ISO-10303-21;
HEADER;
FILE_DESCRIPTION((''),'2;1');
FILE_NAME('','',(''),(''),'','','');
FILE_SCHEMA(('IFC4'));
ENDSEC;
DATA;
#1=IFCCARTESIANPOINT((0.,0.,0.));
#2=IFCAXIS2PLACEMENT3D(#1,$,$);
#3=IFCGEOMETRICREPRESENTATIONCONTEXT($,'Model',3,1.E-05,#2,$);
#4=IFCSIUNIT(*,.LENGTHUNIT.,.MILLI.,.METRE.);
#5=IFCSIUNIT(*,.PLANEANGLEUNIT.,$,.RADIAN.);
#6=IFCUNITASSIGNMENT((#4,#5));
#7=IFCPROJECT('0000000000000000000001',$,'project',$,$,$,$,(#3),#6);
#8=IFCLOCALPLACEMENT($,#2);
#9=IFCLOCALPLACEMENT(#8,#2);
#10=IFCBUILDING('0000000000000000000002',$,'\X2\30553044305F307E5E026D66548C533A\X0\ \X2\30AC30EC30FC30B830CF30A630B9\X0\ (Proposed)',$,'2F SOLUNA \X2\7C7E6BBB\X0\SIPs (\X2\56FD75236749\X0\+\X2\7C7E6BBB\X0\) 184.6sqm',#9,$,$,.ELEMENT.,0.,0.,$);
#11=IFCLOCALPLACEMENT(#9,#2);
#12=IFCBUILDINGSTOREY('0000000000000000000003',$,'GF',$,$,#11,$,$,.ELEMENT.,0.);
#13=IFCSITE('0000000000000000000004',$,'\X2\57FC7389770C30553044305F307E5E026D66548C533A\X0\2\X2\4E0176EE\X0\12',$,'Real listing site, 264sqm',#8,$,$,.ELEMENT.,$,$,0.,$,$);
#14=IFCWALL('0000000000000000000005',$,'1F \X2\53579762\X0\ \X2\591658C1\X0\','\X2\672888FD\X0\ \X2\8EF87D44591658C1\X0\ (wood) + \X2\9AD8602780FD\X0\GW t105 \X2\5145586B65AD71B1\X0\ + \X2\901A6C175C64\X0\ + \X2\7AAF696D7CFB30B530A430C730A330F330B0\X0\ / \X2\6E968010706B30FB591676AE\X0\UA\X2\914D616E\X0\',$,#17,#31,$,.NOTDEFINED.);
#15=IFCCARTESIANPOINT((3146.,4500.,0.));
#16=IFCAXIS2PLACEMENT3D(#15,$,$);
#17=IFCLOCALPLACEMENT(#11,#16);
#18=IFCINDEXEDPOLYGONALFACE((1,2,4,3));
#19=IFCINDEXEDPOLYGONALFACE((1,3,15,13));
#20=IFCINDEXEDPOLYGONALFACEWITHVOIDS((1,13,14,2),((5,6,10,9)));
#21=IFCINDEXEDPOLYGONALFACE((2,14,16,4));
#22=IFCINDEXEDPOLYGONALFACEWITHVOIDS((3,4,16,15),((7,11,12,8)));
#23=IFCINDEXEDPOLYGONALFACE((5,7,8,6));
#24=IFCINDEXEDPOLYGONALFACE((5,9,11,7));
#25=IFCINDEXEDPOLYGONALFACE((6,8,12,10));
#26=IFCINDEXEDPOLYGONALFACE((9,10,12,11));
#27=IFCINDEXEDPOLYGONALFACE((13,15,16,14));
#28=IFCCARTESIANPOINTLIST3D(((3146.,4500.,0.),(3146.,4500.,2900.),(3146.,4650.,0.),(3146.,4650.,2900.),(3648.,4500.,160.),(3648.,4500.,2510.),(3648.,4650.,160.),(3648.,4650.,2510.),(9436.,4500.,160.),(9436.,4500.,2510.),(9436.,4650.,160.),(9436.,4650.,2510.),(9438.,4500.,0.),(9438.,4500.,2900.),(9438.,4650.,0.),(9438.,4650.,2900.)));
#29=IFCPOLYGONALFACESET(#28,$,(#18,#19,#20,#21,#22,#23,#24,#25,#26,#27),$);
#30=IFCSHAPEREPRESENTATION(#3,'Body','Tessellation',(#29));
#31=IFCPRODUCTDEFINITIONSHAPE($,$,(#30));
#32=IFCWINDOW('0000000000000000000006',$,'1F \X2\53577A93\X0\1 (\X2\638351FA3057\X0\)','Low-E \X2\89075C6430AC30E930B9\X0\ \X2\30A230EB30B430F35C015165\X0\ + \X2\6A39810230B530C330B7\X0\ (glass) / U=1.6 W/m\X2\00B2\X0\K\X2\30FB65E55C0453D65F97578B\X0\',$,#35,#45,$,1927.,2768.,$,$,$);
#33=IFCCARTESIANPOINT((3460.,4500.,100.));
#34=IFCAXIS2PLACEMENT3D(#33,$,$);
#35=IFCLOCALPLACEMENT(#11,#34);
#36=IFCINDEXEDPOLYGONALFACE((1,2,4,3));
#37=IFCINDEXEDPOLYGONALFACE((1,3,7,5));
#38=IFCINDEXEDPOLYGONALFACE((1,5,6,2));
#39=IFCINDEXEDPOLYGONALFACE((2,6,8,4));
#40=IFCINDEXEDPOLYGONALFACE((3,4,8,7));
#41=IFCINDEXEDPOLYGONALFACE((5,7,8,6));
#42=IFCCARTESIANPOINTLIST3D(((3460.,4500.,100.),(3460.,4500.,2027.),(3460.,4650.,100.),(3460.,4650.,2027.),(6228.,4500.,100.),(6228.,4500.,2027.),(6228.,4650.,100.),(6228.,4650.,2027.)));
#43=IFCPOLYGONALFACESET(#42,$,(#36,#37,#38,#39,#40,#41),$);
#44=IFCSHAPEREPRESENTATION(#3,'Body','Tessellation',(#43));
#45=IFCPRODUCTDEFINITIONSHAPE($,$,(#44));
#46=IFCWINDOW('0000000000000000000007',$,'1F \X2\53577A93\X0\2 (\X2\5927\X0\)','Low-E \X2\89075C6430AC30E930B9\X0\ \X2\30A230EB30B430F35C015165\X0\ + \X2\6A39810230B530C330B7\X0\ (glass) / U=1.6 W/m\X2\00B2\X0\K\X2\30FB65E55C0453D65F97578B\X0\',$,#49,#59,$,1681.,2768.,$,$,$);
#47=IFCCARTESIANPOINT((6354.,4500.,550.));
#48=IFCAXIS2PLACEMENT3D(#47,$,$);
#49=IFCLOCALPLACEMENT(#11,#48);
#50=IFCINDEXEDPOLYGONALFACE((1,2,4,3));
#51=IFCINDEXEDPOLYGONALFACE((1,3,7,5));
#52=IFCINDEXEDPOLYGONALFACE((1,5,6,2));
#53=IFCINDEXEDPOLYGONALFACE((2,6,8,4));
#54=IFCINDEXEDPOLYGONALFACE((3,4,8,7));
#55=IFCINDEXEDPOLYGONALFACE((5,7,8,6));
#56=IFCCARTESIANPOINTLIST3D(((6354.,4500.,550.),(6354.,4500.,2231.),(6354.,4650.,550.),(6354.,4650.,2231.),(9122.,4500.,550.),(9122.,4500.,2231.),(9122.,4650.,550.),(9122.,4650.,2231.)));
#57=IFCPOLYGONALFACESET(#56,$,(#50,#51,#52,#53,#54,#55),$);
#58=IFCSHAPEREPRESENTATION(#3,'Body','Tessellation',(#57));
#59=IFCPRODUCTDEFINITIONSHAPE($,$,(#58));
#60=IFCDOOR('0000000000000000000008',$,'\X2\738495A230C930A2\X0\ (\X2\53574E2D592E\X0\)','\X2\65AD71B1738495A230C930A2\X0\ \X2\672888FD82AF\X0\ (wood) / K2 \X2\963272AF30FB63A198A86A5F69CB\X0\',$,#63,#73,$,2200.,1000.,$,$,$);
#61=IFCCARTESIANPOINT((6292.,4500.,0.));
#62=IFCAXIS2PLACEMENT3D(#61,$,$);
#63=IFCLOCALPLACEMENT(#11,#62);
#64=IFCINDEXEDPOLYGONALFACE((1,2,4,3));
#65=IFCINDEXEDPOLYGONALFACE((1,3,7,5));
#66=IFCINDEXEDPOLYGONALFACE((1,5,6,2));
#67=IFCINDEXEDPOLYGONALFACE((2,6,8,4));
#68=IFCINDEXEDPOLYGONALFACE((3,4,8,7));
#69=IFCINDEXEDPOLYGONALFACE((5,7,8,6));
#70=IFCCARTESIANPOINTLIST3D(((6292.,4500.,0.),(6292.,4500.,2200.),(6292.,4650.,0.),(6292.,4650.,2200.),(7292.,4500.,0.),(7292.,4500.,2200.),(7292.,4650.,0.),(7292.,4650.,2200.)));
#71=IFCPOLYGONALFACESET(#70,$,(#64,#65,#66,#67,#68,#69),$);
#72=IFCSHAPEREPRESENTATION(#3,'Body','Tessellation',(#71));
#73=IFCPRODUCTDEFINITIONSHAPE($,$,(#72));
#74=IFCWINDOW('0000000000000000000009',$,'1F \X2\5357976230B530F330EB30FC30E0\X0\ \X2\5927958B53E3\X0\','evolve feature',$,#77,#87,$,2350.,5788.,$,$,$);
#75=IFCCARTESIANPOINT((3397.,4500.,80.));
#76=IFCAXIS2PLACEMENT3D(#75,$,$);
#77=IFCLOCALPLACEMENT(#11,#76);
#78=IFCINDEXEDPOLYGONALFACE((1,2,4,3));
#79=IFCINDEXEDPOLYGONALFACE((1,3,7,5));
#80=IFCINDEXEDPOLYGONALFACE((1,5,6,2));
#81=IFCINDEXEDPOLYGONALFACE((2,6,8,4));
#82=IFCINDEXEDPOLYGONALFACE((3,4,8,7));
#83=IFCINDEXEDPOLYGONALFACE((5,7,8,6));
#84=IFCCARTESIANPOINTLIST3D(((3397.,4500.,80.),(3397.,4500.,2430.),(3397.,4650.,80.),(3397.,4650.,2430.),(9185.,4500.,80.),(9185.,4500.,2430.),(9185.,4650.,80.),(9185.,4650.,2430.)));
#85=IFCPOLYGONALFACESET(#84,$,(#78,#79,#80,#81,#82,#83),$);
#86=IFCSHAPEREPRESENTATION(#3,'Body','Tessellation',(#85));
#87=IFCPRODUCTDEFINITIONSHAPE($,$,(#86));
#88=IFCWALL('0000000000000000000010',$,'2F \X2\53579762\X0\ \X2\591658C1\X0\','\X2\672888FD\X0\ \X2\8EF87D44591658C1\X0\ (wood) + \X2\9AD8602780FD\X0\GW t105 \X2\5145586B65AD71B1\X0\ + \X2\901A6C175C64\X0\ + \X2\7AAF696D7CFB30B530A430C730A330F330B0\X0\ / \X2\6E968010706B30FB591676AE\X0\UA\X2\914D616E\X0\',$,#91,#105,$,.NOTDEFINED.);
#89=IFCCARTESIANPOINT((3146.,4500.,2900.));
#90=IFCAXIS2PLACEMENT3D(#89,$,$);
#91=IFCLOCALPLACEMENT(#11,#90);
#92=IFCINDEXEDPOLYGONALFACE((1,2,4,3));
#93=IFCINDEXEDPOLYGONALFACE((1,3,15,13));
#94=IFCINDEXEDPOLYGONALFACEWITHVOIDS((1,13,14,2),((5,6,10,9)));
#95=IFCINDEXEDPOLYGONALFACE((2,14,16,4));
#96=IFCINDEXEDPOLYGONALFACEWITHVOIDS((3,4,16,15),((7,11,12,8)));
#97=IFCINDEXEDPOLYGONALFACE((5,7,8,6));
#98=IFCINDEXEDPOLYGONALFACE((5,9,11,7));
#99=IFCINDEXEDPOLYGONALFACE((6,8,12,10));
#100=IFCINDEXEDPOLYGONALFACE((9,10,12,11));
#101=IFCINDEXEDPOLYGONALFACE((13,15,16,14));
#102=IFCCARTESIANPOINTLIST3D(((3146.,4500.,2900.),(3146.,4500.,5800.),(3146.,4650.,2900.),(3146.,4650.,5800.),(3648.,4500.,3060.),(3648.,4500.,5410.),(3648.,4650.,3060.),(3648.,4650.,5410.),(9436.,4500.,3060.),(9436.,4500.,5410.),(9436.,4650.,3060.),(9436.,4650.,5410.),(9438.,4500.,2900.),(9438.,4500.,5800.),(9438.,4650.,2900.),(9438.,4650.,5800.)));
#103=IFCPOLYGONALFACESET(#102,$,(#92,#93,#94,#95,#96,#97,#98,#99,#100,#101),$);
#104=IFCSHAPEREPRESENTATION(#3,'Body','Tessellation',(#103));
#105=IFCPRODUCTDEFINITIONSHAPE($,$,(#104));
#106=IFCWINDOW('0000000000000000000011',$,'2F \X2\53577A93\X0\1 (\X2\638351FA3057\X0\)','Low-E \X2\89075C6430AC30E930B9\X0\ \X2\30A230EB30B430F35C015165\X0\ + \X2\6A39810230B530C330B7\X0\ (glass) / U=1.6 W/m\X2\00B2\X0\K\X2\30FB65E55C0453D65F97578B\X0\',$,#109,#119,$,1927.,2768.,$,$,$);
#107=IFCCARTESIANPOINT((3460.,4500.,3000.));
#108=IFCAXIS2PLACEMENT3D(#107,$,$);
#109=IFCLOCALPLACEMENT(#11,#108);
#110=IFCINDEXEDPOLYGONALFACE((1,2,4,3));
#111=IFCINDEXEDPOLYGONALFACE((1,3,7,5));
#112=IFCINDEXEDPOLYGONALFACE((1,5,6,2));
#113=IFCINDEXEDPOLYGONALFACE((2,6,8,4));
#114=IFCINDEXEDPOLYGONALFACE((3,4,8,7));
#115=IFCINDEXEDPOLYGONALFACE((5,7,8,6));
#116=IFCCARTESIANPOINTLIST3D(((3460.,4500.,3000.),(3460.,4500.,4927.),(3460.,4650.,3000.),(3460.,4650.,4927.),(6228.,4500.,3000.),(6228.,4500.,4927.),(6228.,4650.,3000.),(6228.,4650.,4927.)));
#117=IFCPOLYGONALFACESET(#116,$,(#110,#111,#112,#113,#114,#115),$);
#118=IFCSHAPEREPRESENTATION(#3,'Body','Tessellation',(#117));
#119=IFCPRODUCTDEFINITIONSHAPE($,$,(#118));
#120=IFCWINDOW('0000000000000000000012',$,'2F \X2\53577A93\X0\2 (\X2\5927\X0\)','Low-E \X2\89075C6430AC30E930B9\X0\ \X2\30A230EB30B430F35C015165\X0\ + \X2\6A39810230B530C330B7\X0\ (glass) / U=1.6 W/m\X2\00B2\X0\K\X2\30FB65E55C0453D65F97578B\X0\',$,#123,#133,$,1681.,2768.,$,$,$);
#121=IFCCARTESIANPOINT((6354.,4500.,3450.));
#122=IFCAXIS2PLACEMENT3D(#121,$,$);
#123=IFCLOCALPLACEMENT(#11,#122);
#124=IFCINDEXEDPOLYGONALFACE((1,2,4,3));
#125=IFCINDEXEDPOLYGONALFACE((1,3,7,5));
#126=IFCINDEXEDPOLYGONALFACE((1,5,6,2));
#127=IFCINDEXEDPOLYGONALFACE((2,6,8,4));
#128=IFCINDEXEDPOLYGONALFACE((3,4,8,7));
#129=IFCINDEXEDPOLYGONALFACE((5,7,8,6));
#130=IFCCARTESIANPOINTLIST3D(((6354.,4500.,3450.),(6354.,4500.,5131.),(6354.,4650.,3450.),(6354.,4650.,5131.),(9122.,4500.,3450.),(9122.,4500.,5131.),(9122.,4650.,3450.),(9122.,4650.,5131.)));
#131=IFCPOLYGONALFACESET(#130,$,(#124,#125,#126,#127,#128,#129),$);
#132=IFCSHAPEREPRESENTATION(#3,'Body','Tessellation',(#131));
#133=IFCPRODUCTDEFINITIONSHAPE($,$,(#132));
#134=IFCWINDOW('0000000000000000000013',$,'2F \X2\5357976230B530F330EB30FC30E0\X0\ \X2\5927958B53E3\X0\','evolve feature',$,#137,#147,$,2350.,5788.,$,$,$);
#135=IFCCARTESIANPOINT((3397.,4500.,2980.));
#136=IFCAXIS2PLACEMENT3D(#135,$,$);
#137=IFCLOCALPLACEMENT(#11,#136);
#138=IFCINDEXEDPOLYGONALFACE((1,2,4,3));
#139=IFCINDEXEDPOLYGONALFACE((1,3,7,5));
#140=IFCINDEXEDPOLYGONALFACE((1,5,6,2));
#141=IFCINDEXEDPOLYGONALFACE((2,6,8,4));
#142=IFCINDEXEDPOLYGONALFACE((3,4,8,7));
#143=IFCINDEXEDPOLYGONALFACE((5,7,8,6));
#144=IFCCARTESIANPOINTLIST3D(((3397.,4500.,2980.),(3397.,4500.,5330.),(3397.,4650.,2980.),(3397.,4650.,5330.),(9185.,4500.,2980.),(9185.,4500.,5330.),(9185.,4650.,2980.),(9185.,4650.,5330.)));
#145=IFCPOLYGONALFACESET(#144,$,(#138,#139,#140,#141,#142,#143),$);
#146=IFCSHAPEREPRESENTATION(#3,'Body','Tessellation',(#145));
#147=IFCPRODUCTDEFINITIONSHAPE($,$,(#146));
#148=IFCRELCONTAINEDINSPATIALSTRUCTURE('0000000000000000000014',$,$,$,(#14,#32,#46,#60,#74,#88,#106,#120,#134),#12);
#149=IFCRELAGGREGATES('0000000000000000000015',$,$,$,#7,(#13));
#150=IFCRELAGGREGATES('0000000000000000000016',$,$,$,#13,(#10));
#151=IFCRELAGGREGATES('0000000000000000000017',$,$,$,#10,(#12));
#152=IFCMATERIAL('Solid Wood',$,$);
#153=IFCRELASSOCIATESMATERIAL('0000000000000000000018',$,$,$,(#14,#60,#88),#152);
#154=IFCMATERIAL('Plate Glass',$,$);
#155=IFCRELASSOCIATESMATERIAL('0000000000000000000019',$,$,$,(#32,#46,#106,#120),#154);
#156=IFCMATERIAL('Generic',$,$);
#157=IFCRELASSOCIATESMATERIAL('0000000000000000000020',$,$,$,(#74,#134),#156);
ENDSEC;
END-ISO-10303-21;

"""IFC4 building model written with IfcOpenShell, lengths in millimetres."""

from ifc_helpers import new_model, si_unit, frame, frame_2d, origin, place, context, project, spatial, rectangle, extrude, material, element, fill, save


model = new_model("IFC4")

# Units and contexts
model_context = context("Model", 3, precision=1e-05, world=origin())
ifc_project = project(units=[si_unit("LENGTHUNIT", "METRE", prefix="MILLI"), si_unit("PLANEANGLEUNIT", "RADIAN")], contexts=[model_context])

# Site, building, storey
site_placement = place(None, origin())
site = spatial("IfcSite", under=ifc_project, at=site_placement, Name="埼玉県さいたま市浦和区2丁目12", ObjectType="Real listing site, 264sqm", CompositionType="ELEMENT", RefElevation=0.0)
building_placement = place(site_placement, origin())
building = spatial("IfcBuilding", under=site, at=building_placement, Name="さいたま市浦和区 ガレージハウス (Proposed)", ObjectType="2F SOLUNA 籾殻SIPs (国産杉+籾殻) 184.6sqm", CompositionType="ELEMENT", ElevationOfRefHeight=0.0, ElevationOfTerrain=0.0)
storey_placement = place(building_placement, origin())
storey = spatial("IfcBuildingStorey", under=building, at=storey_placement, Name="GF", CompositionType="ELEMENT", Elevation=0.0)

# Shared definitions
ifc_material_1 = material(Name="Solid Wood")
ifc_material_2 = material(Name="Generic")

# Wall, openings, windows, door
wall_1_placement = place(storey_placement, frame((3146.0, 4500.0, 0.0)))
wall_1 = element("IfcWall", 1, at=wall_1_placement, inside=storey, material=ifc_material_1, Name="1F 南面 外壁", Description="木製 軸組外壁 (wood) + 高性能GW t105 充填断熱 + 通気層 + 窯業系サイディング / 準耐火・外皮UA配慮", PredefinedType="NOTDEFINED", context=model_context, shape_type="SweptSolid", body=[
    extrude(rectangle(XDim=6292.0, YDim=150.0, at=frame_2d((3146.0, 75.0))), frame((3146.0, 4500.0, 0.0)), (0.0, 0.0, 1.0), 2900.0),
])
opening_1_placement = place(storey_placement, frame((3460.0, 4500.0, 100.0)))
opening_1 = element("IfcOpeningElement", 2, at=opening_1_placement, cuts=wall_1, PredefinedType="NOTDEFINED", context=model_context, shape_type="SweptSolid", body=[
    extrude(rectangle(XDim=2768.0, YDim=150.0, at=frame_2d((1384.0, 75.0))), frame((3460.0, 4500.0, 100.0)), (0.0, 0.0, 1.0), 1927.0),
])
opening_2_placement = place(storey_placement, frame((6354.0, 4500.0, 550.0)))
opening_2 = element("IfcOpeningElement", 3, at=opening_2_placement, cuts=wall_1, PredefinedType="NOTDEFINED", context=model_context, shape_type="SweptSolid", body=[
    extrude(rectangle(XDim=2768.0, YDim=150.0, at=frame_2d((1384.0, 75.0))), frame((6354.0, 4500.0, 550.0)), (0.0, 0.0, 1.0), 1681.0),
])
opening_3_placement = place(storey_placement, frame((6292.0, 4500.0, 0.0)))
opening_3 = element("IfcOpeningElement", 4, at=opening_3_placement, cuts=wall_1, PredefinedType="NOTDEFINED", context=model_context, shape_type="SweptSolid", body=[
    extrude(rectangle(XDim=1000.0, YDim=150.0, at=frame_2d((500.0, 75.0))), frame((6292.0, 4500.0, 0.0)), (0.0, 0.0, 1.0), 2200.0),
])
opening_4_placement = place(storey_placement, frame((3397.0, 4500.0, 80.0)))
opening_4 = element("IfcOpeningElement", 5, at=opening_4_placement, cuts=wall_1, PredefinedType="NOTDEFINED", context=model_context, shape_type="SweptSolid", body=[
    extrude(rectangle(XDim=5788.0, YDim=150.0, at=frame_2d((2894.0, 75.0))), frame((3397.0, 4500.0, 80.0)), (0.0, 0.0, 1.0), 2350.0),
])
ifc_material_3 = material(Name="Plate Glass")
window_1_placement = place(storey_placement, frame((3460.0, 4500.0, 100.0)))
window_1 = element("IfcWindow", 6, at=window_1_placement, inside=storey, material=ifc_material_3, Name="1F 南窓1 (掃出し)", Description="Low-E 複層ガラス アルゴン封入 + 樹脂サッシ (glass) / U=1.6 W/m²K・日射取得型", OverallHeight=1927.0, OverallWidth=2768.0, context=model_context, shape_type="SweptSolid", body=[
    extrude(rectangle(XDim=2768.0, YDim=150.0, at=frame_2d((1384.0, 75.0))), frame((3460.0, 4500.0, 100.0)), (0.0, 0.0, 1.0), 1927.0),
])
fill(opening_1, window_1)
window_2_placement = place(storey_placement, frame((6354.0, 4500.0, 550.0)))
window_2 = element("IfcWindow", 7, at=window_2_placement, inside=storey, material=ifc_material_3, Name="1F 南窓2 (大)", Description="Low-E 複層ガラス アルゴン封入 + 樹脂サッシ (glass) / U=1.6 W/m²K・日射取得型", OverallHeight=1681.0, OverallWidth=2768.0, context=model_context, shape_type="SweptSolid", body=[
    extrude(rectangle(XDim=2768.0, YDim=150.0, at=frame_2d((1384.0, 75.0))), frame((6354.0, 4500.0, 550.0)), (0.0, 0.0, 1.0), 1681.0),
])
fill(opening_2, window_2)
door_placement = place(storey_placement, frame((6292.0, 4500.0, 0.0)))
door = element("IfcDoor", 8, at=door_placement, inside=storey, material=ifc_material_1, Name="玄関ドア (南中央)", Description="断熱玄関ドア 木製芯 (wood) / K2 防犯・採風機構", OverallHeight=2200.0, OverallWidth=1000.0, context=model_context, shape_type="SweptSolid", body=[
    extrude(rectangle(XDim=1000.0, YDim=150.0, at=frame_2d((500.0, 75.0))), frame((6292.0, 4500.0, 0.0)), (0.0, 0.0, 1.0), 2200.0),
])
fill(opening_3, door)
window_3_placement = place(storey_placement, frame((3397.0, 4500.0, 80.0)))
window_3 = element("IfcWindow", 9, at=window_3_placement, inside=storey, material=ifc_material_2, Name="1F 南面サンルーム 大開口", Description="evolve feature", OverallHeight=2350.0, OverallWidth=5788.0, context=model_context, shape_type="SweptSolid", body=[
    extrude(rectangle(XDim=5788.0, YDim=150.0, at=frame_2d((2894.0, 75.0))), frame((3397.0, 4500.0, 80.0)), (0.0, 0.0, 1.0), 2350.0),
])
fill(opening_4, window_3)

# Wall, openings, windows
wall_2_placement = place(storey_placement, frame((3146.0, 4500.0, 2900.0)))
wall_2 = element("IfcWall", 10, at=wall_2_placement, inside=storey, material=ifc_material_1, Name="2F 南面 外壁", Description="木製 軸組外壁 (wood) + 高性能GW t105 充填断熱 + 通気層 + 窯業系サイディング / 準耐火・外皮UA配慮", PredefinedType="NOTDEFINED", context=model_context, shape_type="SweptSolid", body=[
    extrude(rectangle(XDim=6292.0, YDim=150.0, at=frame_2d((3146.0, 75.0))), frame((3146.0, 4500.0, 2900.0)), (0.0, 0.0, 1.0), 2900.0),
])
opening_5_placement = place(storey_placement, frame((3460.0, 4500.0, 3000.0)))
opening_5 = element("IfcOpeningElement", 11, at=opening_5_placement, cuts=wall_2, PredefinedType="NOTDEFINED", context=model_context, shape_type="SweptSolid", body=[
    extrude(rectangle(XDim=2768.0, YDim=150.0, at=frame_2d((1384.0, 75.0))), frame((3460.0, 4500.0, 3000.0)), (0.0, 0.0, 1.0), 1927.0),
])
opening_6_placement = place(storey_placement, frame((6354.0, 4500.0, 3450.0)))
opening_6 = element("IfcOpeningElement", 12, at=opening_6_placement, cuts=wall_2, PredefinedType="NOTDEFINED", context=model_context, shape_type="SweptSolid", body=[
    extrude(rectangle(XDim=2768.0, YDim=150.0, at=frame_2d((1384.0, 75.0))), frame((6354.0, 4500.0, 3450.0)), (0.0, 0.0, 1.0), 1681.0),
])
opening_7_placement = place(storey_placement, frame((3397.0, 4500.0, 2980.0)))
opening_7 = element("IfcOpeningElement", 13, at=opening_7_placement, cuts=wall_2, PredefinedType="NOTDEFINED", context=model_context, shape_type="SweptSolid", body=[
    extrude(rectangle(XDim=5788.0, YDim=150.0, at=frame_2d((2894.0, 75.0))), frame((3397.0, 4500.0, 2980.0)), (0.0, 0.0, 1.0), 2350.0),
])
window_4_placement = place(storey_placement, frame((3460.0, 4500.0, 3000.0)))
window_4 = element("IfcWindow", 14, at=window_4_placement, inside=storey, material=ifc_material_3, Name="2F 南窓1 (掃出し)", Description="Low-E 複層ガラス アルゴン封入 + 樹脂サッシ (glass) / U=1.6 W/m²K・日射取得型", OverallHeight=1927.0, OverallWidth=2768.0, context=model_context, shape_type="SweptSolid", body=[
    extrude(rectangle(XDim=2768.0, YDim=150.0, at=frame_2d((1384.0, 75.0))), frame((3460.0, 4500.0, 3000.0)), (0.0, 0.0, 1.0), 1927.0),
])
fill(opening_5, window_4)
window_5_placement = place(storey_placement, frame((6354.0, 4500.0, 3450.0)))
window_5 = element("IfcWindow", 15, at=window_5_placement, inside=storey, material=ifc_material_3, Name="2F 南窓2 (大)", Description="Low-E 複層ガラス アルゴン封入 + 樹脂サッシ (glass) / U=1.6 W/m²K・日射取得型", OverallHeight=1681.0, OverallWidth=2768.0, context=model_context, shape_type="SweptSolid", body=[
    extrude(rectangle(XDim=2768.0, YDim=150.0, at=frame_2d((1384.0, 75.0))), frame((6354.0, 4500.0, 3450.0)), (0.0, 0.0, 1.0), 1681.0),
])
fill(opening_6, window_5)
window_6_placement = place(storey_placement, frame((3397.0, 4500.0, 2980.0)))
window_6 = element("IfcWindow", 16, at=window_6_placement, inside=storey, material=ifc_material_2, Name="2F 南面サンルーム 大開口", Description="evolve feature", OverallHeight=2350.0, OverallWidth=5788.0, context=model_context, shape_type="SweptSolid", body=[
    extrude(rectangle(XDim=5788.0, YDim=150.0, at=frame_2d((2894.0, 75.0))), frame((3397.0, 4500.0, 2980.0)), (0.0, 0.0, 1.0), 2350.0),
])
fill(opening_7, window_6)

save(model, "model.ifc")
